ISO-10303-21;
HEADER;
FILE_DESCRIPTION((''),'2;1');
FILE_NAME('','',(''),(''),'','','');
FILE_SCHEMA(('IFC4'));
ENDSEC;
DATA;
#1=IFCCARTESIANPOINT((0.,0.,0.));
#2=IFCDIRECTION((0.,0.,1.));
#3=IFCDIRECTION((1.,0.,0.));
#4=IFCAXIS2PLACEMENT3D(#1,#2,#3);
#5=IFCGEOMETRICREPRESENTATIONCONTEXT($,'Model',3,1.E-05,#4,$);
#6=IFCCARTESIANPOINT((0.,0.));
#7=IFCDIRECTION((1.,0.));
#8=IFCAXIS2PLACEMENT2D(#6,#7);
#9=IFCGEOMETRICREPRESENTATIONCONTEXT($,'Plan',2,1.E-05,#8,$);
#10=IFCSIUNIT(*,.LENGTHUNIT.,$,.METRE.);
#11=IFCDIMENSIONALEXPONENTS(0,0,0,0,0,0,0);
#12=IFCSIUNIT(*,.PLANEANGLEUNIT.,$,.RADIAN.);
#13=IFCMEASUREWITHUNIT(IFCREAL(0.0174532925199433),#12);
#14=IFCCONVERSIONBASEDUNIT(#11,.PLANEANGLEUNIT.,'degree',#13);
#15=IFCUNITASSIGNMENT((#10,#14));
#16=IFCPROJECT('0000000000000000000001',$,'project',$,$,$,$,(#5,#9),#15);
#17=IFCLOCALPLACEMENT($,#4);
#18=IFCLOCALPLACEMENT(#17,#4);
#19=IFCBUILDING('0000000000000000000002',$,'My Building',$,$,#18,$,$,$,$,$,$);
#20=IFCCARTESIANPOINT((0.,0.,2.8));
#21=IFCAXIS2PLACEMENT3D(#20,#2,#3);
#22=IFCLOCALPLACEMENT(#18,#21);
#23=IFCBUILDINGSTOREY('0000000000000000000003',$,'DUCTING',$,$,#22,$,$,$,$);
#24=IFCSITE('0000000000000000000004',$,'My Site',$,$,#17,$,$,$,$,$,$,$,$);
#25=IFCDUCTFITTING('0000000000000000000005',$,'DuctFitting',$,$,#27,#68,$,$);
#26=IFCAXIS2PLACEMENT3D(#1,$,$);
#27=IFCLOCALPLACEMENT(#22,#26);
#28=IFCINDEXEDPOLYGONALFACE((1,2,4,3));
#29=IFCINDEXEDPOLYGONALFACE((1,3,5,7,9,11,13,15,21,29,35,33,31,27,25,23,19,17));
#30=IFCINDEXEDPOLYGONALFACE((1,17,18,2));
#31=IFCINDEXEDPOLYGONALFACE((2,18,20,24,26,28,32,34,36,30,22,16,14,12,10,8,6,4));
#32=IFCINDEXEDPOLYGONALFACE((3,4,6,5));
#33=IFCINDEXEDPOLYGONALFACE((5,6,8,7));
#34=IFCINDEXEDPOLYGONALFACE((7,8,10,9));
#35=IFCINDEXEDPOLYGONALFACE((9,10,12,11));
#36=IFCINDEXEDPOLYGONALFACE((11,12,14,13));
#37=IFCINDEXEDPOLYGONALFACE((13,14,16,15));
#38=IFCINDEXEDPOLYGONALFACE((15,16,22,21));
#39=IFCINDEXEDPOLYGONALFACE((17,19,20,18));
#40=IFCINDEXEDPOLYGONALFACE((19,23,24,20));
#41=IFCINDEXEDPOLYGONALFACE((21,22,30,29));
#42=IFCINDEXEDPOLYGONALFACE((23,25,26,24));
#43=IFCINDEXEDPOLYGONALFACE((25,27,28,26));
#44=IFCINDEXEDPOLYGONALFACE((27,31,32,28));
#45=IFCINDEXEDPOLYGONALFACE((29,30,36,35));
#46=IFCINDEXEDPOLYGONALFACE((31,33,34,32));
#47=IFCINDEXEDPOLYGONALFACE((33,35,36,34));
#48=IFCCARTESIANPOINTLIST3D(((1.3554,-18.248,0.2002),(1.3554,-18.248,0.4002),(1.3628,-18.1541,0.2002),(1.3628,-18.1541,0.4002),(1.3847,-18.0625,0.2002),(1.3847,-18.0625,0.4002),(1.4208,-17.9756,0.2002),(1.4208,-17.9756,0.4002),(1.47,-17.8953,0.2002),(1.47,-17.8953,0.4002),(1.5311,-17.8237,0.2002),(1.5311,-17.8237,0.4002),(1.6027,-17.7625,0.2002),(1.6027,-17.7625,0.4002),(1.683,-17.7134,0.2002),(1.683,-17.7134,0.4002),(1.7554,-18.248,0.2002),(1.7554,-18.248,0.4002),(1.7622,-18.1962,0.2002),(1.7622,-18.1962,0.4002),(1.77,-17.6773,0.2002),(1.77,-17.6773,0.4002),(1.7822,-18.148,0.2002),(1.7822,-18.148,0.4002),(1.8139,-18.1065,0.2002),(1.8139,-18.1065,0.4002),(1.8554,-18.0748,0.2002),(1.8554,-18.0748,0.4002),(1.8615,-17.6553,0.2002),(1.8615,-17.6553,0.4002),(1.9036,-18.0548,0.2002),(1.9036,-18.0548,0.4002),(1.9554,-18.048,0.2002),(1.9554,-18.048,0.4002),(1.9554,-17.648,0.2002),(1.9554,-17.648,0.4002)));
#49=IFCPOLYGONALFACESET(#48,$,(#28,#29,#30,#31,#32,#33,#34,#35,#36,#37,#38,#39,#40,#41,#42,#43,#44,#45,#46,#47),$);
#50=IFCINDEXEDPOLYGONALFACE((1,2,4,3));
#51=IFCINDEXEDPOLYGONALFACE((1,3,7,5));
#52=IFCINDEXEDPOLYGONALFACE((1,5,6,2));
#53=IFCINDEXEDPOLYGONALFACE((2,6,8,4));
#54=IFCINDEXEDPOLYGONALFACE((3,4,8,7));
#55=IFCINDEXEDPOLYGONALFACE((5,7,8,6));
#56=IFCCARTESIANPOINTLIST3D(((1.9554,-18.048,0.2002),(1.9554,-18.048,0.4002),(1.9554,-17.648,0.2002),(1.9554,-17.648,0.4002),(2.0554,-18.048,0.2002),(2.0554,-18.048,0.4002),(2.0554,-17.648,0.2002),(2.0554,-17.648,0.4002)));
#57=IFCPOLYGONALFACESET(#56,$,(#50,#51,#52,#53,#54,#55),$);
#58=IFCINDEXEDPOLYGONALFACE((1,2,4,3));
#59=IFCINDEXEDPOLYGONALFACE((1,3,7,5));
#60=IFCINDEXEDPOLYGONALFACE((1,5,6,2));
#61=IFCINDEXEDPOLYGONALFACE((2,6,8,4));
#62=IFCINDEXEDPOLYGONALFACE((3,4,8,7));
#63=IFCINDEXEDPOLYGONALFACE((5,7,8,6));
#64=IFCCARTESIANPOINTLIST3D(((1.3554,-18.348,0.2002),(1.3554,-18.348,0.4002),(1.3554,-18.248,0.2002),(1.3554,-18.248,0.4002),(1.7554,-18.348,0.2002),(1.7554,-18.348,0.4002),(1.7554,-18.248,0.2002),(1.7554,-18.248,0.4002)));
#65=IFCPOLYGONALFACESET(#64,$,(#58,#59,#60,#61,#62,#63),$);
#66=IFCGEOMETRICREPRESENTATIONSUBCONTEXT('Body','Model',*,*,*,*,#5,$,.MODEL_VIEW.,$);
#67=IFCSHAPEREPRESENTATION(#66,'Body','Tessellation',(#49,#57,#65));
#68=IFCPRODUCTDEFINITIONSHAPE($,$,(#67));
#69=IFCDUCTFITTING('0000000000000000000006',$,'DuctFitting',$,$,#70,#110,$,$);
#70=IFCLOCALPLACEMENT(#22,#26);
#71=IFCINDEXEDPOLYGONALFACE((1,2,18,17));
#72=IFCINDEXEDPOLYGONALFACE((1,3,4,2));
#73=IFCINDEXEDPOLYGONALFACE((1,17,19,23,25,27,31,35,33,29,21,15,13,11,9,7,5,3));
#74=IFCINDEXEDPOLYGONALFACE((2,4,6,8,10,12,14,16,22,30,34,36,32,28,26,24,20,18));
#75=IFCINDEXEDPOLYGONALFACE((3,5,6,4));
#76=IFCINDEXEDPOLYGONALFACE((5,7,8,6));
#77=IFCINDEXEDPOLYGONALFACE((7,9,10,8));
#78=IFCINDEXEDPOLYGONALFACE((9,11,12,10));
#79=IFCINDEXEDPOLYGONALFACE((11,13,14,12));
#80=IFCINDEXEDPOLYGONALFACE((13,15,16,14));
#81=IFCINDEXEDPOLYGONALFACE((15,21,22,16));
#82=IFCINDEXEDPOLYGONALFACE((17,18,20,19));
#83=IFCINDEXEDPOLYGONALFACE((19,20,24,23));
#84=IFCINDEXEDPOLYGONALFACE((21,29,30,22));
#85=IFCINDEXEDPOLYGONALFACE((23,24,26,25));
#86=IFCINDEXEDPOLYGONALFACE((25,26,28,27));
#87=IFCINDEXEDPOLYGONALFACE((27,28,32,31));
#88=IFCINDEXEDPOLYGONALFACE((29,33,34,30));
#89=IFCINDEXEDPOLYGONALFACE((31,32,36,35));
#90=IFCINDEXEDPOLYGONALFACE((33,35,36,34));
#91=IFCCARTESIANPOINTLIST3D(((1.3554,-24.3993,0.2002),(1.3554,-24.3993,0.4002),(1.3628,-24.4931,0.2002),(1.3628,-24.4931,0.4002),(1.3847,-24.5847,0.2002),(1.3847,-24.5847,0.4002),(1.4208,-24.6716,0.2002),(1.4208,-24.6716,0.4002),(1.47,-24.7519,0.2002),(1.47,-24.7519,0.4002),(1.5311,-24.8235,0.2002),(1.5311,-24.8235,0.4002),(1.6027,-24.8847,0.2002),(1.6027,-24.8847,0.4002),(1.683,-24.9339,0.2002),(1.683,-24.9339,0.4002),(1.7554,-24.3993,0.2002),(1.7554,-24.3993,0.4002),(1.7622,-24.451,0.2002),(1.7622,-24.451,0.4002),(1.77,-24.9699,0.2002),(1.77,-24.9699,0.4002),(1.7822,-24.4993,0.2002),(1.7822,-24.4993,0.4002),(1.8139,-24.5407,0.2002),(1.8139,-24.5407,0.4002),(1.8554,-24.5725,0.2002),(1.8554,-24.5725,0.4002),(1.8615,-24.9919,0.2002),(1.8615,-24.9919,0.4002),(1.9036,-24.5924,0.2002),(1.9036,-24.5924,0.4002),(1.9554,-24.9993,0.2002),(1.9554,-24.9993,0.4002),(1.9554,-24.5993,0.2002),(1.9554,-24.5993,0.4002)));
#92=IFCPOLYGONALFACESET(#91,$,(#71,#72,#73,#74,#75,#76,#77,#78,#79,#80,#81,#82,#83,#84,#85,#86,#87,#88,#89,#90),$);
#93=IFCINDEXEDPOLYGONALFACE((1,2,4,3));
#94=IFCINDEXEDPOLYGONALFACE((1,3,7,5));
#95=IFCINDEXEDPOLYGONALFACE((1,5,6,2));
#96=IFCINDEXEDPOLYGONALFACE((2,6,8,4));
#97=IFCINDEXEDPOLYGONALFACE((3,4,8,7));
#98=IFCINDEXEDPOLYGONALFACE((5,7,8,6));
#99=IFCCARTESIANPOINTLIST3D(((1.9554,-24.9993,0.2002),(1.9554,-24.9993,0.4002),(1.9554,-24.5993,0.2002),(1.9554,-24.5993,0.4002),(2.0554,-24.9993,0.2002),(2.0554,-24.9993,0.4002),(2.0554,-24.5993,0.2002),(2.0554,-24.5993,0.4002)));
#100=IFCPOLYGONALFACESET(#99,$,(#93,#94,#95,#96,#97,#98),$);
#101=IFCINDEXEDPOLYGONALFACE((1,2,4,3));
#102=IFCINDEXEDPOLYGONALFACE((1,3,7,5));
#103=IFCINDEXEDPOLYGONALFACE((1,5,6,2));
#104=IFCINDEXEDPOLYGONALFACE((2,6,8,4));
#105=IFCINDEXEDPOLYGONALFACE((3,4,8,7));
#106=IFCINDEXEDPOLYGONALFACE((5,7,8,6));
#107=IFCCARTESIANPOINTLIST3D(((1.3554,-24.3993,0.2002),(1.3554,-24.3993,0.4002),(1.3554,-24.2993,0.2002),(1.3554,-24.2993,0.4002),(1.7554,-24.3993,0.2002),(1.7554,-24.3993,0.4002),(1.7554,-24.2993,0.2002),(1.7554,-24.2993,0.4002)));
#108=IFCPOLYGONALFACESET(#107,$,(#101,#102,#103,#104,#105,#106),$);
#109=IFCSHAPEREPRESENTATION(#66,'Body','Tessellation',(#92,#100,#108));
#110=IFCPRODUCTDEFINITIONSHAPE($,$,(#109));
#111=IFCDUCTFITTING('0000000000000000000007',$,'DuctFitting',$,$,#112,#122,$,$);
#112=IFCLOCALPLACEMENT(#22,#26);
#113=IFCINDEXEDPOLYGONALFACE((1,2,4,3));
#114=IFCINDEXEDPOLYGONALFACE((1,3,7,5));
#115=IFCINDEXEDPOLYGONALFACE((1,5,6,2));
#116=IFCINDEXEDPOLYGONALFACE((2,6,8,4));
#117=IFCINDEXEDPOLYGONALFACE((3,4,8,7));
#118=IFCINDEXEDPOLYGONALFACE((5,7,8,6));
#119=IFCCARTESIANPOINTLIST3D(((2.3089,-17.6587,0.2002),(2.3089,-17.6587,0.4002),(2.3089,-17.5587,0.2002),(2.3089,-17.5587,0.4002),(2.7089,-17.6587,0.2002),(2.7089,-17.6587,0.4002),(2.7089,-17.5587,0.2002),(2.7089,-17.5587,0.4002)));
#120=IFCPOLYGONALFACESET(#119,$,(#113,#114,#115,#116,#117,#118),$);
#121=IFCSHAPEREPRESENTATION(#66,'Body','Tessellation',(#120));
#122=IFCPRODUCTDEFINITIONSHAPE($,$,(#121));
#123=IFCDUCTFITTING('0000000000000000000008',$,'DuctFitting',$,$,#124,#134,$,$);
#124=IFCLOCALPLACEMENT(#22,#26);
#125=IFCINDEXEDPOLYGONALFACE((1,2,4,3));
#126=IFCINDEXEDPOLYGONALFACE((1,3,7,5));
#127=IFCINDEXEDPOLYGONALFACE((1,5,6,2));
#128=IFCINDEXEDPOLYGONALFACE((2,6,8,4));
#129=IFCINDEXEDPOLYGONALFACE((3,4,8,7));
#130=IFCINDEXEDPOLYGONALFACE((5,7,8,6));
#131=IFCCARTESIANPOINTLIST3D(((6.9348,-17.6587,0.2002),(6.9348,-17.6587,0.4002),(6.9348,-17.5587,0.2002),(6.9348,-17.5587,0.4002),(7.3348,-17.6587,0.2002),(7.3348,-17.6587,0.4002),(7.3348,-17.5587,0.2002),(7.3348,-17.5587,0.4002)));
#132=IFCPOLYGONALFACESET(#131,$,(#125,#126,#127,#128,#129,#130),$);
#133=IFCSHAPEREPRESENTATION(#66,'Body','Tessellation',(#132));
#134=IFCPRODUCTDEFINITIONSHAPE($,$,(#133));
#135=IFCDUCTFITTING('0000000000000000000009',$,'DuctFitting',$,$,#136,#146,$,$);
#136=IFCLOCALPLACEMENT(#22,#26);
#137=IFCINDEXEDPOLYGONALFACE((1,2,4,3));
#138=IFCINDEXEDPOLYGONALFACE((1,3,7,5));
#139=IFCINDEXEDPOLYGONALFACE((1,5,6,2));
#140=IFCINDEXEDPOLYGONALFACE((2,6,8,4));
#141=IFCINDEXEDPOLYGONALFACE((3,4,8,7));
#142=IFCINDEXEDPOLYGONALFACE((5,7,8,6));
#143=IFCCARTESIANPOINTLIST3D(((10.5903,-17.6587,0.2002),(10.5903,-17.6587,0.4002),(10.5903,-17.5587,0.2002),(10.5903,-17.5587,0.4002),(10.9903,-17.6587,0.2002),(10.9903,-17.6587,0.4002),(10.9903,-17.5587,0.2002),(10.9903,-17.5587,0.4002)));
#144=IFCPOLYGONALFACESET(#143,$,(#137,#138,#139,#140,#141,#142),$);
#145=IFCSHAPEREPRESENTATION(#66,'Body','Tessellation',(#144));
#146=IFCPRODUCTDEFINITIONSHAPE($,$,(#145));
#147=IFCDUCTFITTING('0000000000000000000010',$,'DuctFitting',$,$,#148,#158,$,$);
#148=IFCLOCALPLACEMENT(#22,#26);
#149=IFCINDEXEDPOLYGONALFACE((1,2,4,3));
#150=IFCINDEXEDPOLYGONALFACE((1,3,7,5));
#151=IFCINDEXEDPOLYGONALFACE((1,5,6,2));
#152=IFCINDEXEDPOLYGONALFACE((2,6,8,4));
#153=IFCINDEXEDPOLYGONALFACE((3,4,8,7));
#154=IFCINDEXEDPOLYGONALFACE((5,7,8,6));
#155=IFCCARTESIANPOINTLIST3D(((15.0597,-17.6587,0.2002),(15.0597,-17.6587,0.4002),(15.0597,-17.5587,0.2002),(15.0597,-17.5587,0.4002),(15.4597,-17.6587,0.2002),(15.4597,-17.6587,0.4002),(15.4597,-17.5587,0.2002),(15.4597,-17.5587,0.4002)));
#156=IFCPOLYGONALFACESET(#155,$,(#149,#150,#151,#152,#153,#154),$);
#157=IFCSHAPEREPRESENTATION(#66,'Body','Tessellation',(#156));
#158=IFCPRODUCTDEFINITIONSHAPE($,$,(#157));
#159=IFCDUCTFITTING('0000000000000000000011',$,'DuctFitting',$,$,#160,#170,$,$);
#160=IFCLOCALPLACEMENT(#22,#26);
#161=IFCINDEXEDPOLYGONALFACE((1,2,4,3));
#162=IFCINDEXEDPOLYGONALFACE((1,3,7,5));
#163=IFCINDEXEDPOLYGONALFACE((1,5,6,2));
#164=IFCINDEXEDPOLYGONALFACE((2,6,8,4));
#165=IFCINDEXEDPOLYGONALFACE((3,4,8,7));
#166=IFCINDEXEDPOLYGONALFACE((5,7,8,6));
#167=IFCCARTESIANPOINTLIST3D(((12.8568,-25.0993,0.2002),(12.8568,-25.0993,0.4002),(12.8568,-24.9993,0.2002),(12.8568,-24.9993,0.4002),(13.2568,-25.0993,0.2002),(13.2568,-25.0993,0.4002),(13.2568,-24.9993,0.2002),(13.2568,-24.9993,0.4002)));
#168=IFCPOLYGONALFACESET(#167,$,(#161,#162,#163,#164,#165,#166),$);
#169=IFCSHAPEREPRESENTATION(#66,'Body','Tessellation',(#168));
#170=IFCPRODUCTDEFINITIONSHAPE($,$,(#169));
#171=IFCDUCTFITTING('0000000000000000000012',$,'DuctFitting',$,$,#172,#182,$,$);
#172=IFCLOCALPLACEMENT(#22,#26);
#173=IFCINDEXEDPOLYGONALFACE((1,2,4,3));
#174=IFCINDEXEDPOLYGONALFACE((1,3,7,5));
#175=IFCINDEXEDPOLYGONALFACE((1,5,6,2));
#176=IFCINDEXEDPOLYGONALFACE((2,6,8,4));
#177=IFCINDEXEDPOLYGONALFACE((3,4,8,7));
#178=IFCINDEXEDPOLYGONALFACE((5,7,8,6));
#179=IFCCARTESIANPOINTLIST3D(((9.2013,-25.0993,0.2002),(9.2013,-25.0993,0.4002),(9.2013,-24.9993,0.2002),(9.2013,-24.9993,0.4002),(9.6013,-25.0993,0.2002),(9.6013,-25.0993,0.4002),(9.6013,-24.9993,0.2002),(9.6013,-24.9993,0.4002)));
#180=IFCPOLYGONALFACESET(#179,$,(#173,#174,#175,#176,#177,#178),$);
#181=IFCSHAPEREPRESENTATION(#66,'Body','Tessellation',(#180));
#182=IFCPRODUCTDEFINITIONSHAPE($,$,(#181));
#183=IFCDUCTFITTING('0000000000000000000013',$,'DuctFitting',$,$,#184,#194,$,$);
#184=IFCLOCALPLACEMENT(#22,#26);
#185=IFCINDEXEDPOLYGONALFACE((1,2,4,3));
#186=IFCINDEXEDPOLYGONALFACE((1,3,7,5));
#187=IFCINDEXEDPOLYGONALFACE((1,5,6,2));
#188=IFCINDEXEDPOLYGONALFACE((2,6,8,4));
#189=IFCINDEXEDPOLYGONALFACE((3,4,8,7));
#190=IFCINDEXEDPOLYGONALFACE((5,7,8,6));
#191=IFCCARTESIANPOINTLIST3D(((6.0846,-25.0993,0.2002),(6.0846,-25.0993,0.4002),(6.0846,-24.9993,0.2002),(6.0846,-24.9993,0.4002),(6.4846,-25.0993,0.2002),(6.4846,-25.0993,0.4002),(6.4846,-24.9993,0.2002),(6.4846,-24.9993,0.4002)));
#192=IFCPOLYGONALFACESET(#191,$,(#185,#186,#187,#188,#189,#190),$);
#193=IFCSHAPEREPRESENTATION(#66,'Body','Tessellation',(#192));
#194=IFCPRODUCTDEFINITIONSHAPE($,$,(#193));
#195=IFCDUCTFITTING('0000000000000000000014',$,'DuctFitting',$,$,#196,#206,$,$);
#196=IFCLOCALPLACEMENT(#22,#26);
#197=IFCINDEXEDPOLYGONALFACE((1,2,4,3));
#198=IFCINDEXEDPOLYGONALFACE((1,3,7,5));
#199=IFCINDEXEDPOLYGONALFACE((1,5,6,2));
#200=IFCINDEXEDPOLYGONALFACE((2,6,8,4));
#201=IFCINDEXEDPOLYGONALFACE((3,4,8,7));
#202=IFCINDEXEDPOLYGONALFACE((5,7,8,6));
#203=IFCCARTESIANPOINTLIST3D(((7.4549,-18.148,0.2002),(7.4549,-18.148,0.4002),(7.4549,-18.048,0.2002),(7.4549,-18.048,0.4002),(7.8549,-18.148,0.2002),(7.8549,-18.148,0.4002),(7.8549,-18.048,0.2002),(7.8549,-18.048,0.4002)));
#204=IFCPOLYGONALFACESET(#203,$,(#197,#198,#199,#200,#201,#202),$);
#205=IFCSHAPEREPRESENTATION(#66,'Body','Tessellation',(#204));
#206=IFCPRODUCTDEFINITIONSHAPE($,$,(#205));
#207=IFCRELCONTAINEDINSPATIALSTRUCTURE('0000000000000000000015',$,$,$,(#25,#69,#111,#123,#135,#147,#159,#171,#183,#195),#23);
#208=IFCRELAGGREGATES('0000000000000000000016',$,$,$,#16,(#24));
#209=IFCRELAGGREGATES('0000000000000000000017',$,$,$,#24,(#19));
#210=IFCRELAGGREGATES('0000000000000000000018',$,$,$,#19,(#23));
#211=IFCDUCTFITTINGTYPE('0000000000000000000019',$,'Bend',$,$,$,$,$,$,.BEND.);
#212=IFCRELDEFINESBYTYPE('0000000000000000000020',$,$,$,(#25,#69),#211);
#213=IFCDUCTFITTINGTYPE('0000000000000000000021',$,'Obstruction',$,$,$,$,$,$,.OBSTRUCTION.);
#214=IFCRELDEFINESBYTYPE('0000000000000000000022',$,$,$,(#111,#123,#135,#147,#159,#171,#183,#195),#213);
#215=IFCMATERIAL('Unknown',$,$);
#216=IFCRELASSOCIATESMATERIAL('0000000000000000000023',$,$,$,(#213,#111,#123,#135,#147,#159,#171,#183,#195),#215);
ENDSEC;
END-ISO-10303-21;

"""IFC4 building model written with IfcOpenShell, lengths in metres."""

from ifc_helpers import new_model, entity, si_unit, converted_unit, frame, origin_with_axes, origin_2d_with_axis, place, context, subcontext, project, spatial, line, arc, indexed_curve, rectangle, outline, extrude, source, transform, mapped, material, material_profile, profile_set, profile_usage, type_object, type_shapes, element, save


model = new_model("IFC4")

# Units and contexts
model_context = context("Model", 3, precision=1e-05, world=origin_with_axes())
plan_context = context("Plan", 2, precision=1e-05, world=origin_2d_with_axis())
body_context = subcontext(model_context, "Body", "Model", "MODEL_VIEW")
ifc_project = project(units=[si_unit("LENGTHUNIT", "METRE"), converted_unit("PLANEANGLEUNIT", "degree", entity("IfcReal", 0.0174532925199433), si_unit("PLANEANGLEUNIT", "RADIAN"), dimensions=[0, 0, 0, 0, 0, 0, 0])], contexts=[model_context, plan_context])

# Site, building, storey
site_placement = place(None, origin_with_axes())
site = spatial("IfcSite", under=ifc_project, at=site_placement, Name="My Site")
building_placement = place(site_placement, origin_with_axes())
building = spatial("IfcBuilding", under=site, at=building_placement, Name="My Building")
storey_placement = place(building_placement, frame((0.0, 0.0, 2.8), z_axis=(0.0, 0.0, 1.0), x_axis=(1.0, 0.0, 0.0)))
storey = spatial("IfcBuildingStorey", under=building, at=storey_placement, Name="DUCTING")

# Shared definitions
ifc_material = material(Name="Unknown")

# Duct fittings
duct_fitting_type_1 = type_object("IfcDuctFittingType", Name="Bend", PredefinedType="BEND")
shared_shape = source(origin_with_axes(), body_context, "Body", "SweptSolid", [
    extrude(outline(indexed_curve([(-0.2, 0.0), (-0.2586, 0.1414), (-0.4, 0.2), (-0.4, 0.6), (0.0243, 0.4243), (0.2, 0.0)], segments=[arc(1, 2, 3), line(3, 4), arc(4, 5, 6), line(6, 1)])), frame((0.0, -0.1, 0.1), z_axis=(0.0, -1.0, 0.0), x_axis=(1.0, 0.0, 0.0)), (0.0, 0.0, -1.0), 0.2),
    extrude(rectangle(XDim=0.4, YDim=0.2), origin_with_axes(), (0.0, 0.0, 1.0), 0.1),
    extrude(rectangle(XDim=0.4, YDim=0.2), frame((-0.4, 0.0, 0.5), z_axis=(-1.0, 0.0, 0.000001), x_axis=(-0.000001, 0.0, -1.0)), (0.0, 0.0, 1.0), 0.1),
])
type_shapes(duct_fitting_type_1, [shared_shape])
for number, where, z_axis, x_axis, name in (
    (1, (2.0554, -17.848, 0.3002), (-1.0, 0.000001, -0.000001), (0.000001, 1.0, 0.0), "DuctFitting"),
    (2, (2.0554, -24.7993, 0.3002), (-1.0, 0.000001, -0.000001), (-0.000001, -1.0, 0.0), "DuctFitting"),
):
    element("IfcDuctFitting", number, at=place(storey_placement, frame(where, z_axis=z_axis, x_axis=x_axis)), inside=storey, type_object=duct_fitting_type_1, Name=name, context=body_context, shape_type="MappedRepresentation", body=[
        mapped(shared_shape, transform((0.0, 0.0, 0.0), x_axis=(1.0, 0.0, 0.0), y_axis=(0.0, 1.0, 0.0), z_axis=(0.0, 0.0, 1.0), scale=1.0)),
    ])
ifc_material_profile_1 = material_profile(ifc_material, rectangle(XDim=0.4, YDim=0.2))
ifc_profile_set_1 = profile_set([ifc_material_profile_1])
ifc_profile_usage_1 = profile_usage(ifc_profile_set_1, cardinal=5)
duct_fitting_type_2 = type_object("IfcDuctFittingType", Name="Obstruction", PredefinedType="OBSTRUCTION", material=ifc_profile_set_1)
duct_fitting_1_placement = place(storey_placement, frame((2.5089, -17.6587, 0.3002), z_axis=(0.0, 1.0, 0.0), x_axis=(-1.0, 0.0, 0.0)))
element("IfcDuctFitting", 3, at=duct_fitting_1_placement, inside=storey, type_object=duct_fitting_type_2, material=ifc_profile_usage_1, Name="DuctFitting", context=body_context, shape_type="SweptSolid", body=[
    extrude(rectangle(XDim=0.4, YDim=0.2), origin_with_axes(), (0.0, 0.0, 1.0), 0.1),
])
ifc_profile_usage_2 = profile_usage(ifc_profile_set_1, cardinal=5)
duct_fitting_2_placement = place(storey_placement, frame((7.1348, -17.6587, 0.3002), z_axis=(0.0, 1.0, 0.0), x_axis=(-1.0, 0.0, 0.0)))
element("IfcDuctFitting", 4, at=duct_fitting_2_placement, inside=storey, type_object=duct_fitting_type_2, material=ifc_profile_usage_2, Name="DuctFitting", context=body_context, shape_type="SweptSolid", body=[
    extrude(rectangle(XDim=0.4, YDim=0.2), origin_with_axes(), (0.0, 0.0, 1.0), 0.1),
])
ifc_profile_usage_3 = profile_usage(ifc_profile_set_1, cardinal=5)
duct_fitting_3_placement = place(storey_placement, frame((10.7903, -17.6587, 0.3002), z_axis=(0.0, 1.0, 0.0), x_axis=(-1.0, 0.0, 0.0)))
element("IfcDuctFitting", 5, at=duct_fitting_3_placement, inside=storey, type_object=duct_fitting_type_2, material=ifc_profile_usage_3, Name="DuctFitting", context=body_context, shape_type="SweptSolid", body=[
    extrude(rectangle(XDim=0.4, YDim=0.2), origin_with_axes(), (0.0, 0.0, 1.0), 0.1),
])
ifc_profile_usage_4 = profile_usage(ifc_profile_set_1, cardinal=5)
duct_fitting_4_placement = place(storey_placement, frame((15.2597, -17.6587, 0.3002), z_axis=(0.0, 1.0, 0.0), x_axis=(-1.0, 0.0, 0.0)))
element("IfcDuctFitting", 6, at=duct_fitting_4_placement, inside=storey, type_object=duct_fitting_type_2, material=ifc_profile_usage_4, Name="DuctFitting", context=body_context, shape_type="SweptSolid", body=[
    extrude(rectangle(XDim=0.4, YDim=0.2), origin_with_axes(), (0.0, 0.0, 1.0), 0.1),
])
ifc_profile_usage_5 = profile_usage(ifc_profile_set_1, cardinal=5)
duct_fitting_5_placement = place(storey_placement, frame((13.0568, -24.9993, 0.3002), z_axis=(0.0, -1.0, 0.0), x_axis=(1.0, 0.0, 0.0)))
element("IfcDuctFitting", 7, at=duct_fitting_5_placement, inside=storey, type_object=duct_fitting_type_2, material=ifc_profile_usage_5, Name="DuctFitting", context=body_context, shape_type="SweptSolid", body=[
    extrude(rectangle(XDim=0.4, YDim=0.2), origin_with_axes(), (0.0, 0.0, 1.0), 0.1),
])
ifc_profile_usage_6 = profile_usage(ifc_profile_set_1, cardinal=5)
duct_fitting_6_placement = place(storey_placement, frame((9.4013, -24.9993, 0.3002), z_axis=(0.0, -1.0, 0.0), x_axis=(1.0, 0.0, 0.0)))
element("IfcDuctFitting", 8, at=duct_fitting_6_placement, inside=storey, type_object=duct_fitting_type_2, material=ifc_profile_usage_6, Name="DuctFitting", context=body_context, shape_type="SweptSolid", body=[
    extrude(rectangle(XDim=0.4, YDim=0.2), origin_with_axes(), (0.0, 0.0, 1.0), 0.1),
])
ifc_profile_usage_7 = profile_usage(ifc_profile_set_1, cardinal=5)
duct_fitting_7_placement = place(storey_placement, frame((6.2846, -25.0993, 0.3002), z_axis=(0.0, 1.0, 0.0), x_axis=(-1.0, 0.0, 0.0)))
element("IfcDuctFitting", 9, at=duct_fitting_7_placement, inside=storey, type_object=duct_fitting_type_2, material=ifc_profile_usage_7, Name="DuctFitting", context=body_context, shape_type="SweptSolid", body=[
    extrude(rectangle(XDim=0.4, YDim=0.2), origin_with_axes(), (0.0, 0.0, 1.0), 0.1),
])
ifc_profile_usage_8 = profile_usage(ifc_profile_set_1, cardinal=5)
duct_fitting_8_placement = place(storey_placement, frame((7.6549, -18.048, 0.3002), z_axis=(0.0, -1.0, 0.0), x_axis=(1.0, 0.0, 0.0)))
element("IfcDuctFitting", 10, at=duct_fitting_8_placement, inside=storey, type_object=duct_fitting_type_2, material=ifc_profile_usage_8, Name="DuctFitting", context=body_context, shape_type="SweptSolid", body=[
    extrude(rectangle(XDim=0.4, YDim=0.2), origin_with_axes(), (0.0, 0.0, 1.0), 0.1),
])

save(model, "model.ifc")
